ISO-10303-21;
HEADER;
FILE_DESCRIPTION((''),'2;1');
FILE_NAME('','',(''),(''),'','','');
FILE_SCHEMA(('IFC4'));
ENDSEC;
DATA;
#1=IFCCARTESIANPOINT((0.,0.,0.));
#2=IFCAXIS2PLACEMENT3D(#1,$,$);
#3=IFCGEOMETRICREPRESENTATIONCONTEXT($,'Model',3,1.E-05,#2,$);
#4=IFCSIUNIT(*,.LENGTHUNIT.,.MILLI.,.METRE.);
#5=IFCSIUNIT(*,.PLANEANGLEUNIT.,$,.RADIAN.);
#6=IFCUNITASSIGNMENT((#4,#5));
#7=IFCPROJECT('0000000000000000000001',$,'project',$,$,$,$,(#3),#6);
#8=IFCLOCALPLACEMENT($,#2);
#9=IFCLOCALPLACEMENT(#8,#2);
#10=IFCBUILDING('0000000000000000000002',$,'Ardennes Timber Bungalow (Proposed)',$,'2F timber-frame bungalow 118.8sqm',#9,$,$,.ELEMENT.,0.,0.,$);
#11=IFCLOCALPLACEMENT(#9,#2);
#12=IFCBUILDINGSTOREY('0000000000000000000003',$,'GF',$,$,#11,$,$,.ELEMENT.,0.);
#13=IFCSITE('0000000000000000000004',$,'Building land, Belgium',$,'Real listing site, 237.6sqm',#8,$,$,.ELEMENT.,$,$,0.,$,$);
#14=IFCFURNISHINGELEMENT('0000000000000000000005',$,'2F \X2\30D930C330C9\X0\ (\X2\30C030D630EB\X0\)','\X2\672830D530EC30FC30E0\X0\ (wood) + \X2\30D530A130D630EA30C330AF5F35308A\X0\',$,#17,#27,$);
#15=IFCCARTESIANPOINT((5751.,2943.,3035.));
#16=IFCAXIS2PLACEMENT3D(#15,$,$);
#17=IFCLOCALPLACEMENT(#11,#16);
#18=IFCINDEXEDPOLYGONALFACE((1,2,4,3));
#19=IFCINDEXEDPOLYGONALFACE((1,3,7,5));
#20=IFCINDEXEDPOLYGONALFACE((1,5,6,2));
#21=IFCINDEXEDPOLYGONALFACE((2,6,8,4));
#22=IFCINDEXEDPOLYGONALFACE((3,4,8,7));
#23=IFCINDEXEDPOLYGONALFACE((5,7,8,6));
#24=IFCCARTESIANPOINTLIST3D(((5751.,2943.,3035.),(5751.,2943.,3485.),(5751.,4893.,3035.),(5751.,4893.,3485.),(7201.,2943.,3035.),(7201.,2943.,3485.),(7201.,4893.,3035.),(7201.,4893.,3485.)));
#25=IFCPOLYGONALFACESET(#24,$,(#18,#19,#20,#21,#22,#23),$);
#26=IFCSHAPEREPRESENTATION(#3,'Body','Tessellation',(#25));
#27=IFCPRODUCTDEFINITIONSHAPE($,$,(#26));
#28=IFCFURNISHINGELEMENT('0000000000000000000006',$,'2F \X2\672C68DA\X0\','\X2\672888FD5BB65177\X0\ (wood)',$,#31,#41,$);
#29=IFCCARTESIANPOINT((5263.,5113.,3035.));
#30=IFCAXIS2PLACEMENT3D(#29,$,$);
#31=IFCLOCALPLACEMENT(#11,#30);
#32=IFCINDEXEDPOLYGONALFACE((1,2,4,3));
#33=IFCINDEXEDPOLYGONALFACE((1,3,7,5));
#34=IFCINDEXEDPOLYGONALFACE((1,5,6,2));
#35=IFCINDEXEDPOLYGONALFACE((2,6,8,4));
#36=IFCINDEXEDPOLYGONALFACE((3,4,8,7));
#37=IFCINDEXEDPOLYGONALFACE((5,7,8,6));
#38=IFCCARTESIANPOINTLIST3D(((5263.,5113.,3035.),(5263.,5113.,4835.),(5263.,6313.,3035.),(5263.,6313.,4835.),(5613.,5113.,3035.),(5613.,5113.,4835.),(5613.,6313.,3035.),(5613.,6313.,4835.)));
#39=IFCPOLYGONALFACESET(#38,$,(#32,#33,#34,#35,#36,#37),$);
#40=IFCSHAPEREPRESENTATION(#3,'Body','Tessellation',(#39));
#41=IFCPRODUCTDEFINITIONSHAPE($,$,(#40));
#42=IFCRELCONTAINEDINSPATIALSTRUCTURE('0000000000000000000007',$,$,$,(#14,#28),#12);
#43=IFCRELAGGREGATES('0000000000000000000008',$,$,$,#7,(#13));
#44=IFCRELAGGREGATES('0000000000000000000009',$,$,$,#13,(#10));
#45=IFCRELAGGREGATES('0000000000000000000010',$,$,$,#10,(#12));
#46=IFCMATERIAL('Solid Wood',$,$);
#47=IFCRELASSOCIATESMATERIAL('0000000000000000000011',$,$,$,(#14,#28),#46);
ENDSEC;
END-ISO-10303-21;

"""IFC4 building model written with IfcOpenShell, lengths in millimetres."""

from ifc_helpers import new_model, si_unit, frame, frame_2d, origin, place, context, project, spatial, rectangle, extrude, material, element, save


model = new_model("IFC4")

# Units and contexts
model_context = context("Model", 3, precision=1e-05, world=origin())
ifc_project = project(units=[si_unit("LENGTHUNIT", "METRE", prefix="MILLI"), si_unit("PLANEANGLEUNIT", "RADIAN")], contexts=[model_context])

# Site, building, storey
site_placement = place(None, origin())
site = spatial("IfcSite", under=ifc_project, at=site_placement, Name="Building land, Belgium", ObjectType="Real listing site, 237.6sqm", CompositionType="ELEMENT", RefElevation=0.0)
building_placement = place(site_placement, origin())
building = spatial("IfcBuilding", under=site, at=building_placement, Name="Ardennes Timber Bungalow (Proposed)", ObjectType="2F timber-frame bungalow 118.8sqm", CompositionType="ELEMENT", ElevationOfRefHeight=0.0, ElevationOfTerrain=0.0)
storey_placement = place(building_placement, origin())
storey = spatial("IfcBuildingStorey", under=building, at=storey_placement, Name="GF", CompositionType="ELEMENT", Elevation=0.0)

# Shared definitions
ifc_material_1 = material(Name="Solid Wood")

# Furnishing elements
furnishing_1_placement = place(storey_placement, frame((5751.0, 2943.0, 3035.0)))
element("IfcFurnishingElement", 1, at=furnishing_1_placement, inside=storey, material=ifc_material_1, Name="2F ベッド (ダブル)", Description="木フレーム (wood) + ファブリック張り", context=model_context, shape_type="SweptSolid", body=[
    extrude(rectangle(XDim=1450.0, YDim=1950.0, at=frame_2d((725.0, 975.0))), frame((5751.0, 2943.0, 3035.0)), (0.0, 0.0, 1.0), 450.0),
])
furnishing_2_placement = place(storey_placement, frame((5263.0, 5113.0, 3035.0)))
element("IfcFurnishingElement", 2, at=furnishing_2_placement, inside=storey, material=ifc_material_1, Name="2F 本棚", Description="木製家具 (wood)", context=model_context, shape_type="SweptSolid", body=[
    extrude(rectangle(XDim=350.0, YDim=1200.0, at=frame_2d((175.0, 600.0))), frame((5263.0, 5113.0, 3035.0)), (0.0, 0.0, 1.0), 1800.0),
])

save(model, "model.ifc")
